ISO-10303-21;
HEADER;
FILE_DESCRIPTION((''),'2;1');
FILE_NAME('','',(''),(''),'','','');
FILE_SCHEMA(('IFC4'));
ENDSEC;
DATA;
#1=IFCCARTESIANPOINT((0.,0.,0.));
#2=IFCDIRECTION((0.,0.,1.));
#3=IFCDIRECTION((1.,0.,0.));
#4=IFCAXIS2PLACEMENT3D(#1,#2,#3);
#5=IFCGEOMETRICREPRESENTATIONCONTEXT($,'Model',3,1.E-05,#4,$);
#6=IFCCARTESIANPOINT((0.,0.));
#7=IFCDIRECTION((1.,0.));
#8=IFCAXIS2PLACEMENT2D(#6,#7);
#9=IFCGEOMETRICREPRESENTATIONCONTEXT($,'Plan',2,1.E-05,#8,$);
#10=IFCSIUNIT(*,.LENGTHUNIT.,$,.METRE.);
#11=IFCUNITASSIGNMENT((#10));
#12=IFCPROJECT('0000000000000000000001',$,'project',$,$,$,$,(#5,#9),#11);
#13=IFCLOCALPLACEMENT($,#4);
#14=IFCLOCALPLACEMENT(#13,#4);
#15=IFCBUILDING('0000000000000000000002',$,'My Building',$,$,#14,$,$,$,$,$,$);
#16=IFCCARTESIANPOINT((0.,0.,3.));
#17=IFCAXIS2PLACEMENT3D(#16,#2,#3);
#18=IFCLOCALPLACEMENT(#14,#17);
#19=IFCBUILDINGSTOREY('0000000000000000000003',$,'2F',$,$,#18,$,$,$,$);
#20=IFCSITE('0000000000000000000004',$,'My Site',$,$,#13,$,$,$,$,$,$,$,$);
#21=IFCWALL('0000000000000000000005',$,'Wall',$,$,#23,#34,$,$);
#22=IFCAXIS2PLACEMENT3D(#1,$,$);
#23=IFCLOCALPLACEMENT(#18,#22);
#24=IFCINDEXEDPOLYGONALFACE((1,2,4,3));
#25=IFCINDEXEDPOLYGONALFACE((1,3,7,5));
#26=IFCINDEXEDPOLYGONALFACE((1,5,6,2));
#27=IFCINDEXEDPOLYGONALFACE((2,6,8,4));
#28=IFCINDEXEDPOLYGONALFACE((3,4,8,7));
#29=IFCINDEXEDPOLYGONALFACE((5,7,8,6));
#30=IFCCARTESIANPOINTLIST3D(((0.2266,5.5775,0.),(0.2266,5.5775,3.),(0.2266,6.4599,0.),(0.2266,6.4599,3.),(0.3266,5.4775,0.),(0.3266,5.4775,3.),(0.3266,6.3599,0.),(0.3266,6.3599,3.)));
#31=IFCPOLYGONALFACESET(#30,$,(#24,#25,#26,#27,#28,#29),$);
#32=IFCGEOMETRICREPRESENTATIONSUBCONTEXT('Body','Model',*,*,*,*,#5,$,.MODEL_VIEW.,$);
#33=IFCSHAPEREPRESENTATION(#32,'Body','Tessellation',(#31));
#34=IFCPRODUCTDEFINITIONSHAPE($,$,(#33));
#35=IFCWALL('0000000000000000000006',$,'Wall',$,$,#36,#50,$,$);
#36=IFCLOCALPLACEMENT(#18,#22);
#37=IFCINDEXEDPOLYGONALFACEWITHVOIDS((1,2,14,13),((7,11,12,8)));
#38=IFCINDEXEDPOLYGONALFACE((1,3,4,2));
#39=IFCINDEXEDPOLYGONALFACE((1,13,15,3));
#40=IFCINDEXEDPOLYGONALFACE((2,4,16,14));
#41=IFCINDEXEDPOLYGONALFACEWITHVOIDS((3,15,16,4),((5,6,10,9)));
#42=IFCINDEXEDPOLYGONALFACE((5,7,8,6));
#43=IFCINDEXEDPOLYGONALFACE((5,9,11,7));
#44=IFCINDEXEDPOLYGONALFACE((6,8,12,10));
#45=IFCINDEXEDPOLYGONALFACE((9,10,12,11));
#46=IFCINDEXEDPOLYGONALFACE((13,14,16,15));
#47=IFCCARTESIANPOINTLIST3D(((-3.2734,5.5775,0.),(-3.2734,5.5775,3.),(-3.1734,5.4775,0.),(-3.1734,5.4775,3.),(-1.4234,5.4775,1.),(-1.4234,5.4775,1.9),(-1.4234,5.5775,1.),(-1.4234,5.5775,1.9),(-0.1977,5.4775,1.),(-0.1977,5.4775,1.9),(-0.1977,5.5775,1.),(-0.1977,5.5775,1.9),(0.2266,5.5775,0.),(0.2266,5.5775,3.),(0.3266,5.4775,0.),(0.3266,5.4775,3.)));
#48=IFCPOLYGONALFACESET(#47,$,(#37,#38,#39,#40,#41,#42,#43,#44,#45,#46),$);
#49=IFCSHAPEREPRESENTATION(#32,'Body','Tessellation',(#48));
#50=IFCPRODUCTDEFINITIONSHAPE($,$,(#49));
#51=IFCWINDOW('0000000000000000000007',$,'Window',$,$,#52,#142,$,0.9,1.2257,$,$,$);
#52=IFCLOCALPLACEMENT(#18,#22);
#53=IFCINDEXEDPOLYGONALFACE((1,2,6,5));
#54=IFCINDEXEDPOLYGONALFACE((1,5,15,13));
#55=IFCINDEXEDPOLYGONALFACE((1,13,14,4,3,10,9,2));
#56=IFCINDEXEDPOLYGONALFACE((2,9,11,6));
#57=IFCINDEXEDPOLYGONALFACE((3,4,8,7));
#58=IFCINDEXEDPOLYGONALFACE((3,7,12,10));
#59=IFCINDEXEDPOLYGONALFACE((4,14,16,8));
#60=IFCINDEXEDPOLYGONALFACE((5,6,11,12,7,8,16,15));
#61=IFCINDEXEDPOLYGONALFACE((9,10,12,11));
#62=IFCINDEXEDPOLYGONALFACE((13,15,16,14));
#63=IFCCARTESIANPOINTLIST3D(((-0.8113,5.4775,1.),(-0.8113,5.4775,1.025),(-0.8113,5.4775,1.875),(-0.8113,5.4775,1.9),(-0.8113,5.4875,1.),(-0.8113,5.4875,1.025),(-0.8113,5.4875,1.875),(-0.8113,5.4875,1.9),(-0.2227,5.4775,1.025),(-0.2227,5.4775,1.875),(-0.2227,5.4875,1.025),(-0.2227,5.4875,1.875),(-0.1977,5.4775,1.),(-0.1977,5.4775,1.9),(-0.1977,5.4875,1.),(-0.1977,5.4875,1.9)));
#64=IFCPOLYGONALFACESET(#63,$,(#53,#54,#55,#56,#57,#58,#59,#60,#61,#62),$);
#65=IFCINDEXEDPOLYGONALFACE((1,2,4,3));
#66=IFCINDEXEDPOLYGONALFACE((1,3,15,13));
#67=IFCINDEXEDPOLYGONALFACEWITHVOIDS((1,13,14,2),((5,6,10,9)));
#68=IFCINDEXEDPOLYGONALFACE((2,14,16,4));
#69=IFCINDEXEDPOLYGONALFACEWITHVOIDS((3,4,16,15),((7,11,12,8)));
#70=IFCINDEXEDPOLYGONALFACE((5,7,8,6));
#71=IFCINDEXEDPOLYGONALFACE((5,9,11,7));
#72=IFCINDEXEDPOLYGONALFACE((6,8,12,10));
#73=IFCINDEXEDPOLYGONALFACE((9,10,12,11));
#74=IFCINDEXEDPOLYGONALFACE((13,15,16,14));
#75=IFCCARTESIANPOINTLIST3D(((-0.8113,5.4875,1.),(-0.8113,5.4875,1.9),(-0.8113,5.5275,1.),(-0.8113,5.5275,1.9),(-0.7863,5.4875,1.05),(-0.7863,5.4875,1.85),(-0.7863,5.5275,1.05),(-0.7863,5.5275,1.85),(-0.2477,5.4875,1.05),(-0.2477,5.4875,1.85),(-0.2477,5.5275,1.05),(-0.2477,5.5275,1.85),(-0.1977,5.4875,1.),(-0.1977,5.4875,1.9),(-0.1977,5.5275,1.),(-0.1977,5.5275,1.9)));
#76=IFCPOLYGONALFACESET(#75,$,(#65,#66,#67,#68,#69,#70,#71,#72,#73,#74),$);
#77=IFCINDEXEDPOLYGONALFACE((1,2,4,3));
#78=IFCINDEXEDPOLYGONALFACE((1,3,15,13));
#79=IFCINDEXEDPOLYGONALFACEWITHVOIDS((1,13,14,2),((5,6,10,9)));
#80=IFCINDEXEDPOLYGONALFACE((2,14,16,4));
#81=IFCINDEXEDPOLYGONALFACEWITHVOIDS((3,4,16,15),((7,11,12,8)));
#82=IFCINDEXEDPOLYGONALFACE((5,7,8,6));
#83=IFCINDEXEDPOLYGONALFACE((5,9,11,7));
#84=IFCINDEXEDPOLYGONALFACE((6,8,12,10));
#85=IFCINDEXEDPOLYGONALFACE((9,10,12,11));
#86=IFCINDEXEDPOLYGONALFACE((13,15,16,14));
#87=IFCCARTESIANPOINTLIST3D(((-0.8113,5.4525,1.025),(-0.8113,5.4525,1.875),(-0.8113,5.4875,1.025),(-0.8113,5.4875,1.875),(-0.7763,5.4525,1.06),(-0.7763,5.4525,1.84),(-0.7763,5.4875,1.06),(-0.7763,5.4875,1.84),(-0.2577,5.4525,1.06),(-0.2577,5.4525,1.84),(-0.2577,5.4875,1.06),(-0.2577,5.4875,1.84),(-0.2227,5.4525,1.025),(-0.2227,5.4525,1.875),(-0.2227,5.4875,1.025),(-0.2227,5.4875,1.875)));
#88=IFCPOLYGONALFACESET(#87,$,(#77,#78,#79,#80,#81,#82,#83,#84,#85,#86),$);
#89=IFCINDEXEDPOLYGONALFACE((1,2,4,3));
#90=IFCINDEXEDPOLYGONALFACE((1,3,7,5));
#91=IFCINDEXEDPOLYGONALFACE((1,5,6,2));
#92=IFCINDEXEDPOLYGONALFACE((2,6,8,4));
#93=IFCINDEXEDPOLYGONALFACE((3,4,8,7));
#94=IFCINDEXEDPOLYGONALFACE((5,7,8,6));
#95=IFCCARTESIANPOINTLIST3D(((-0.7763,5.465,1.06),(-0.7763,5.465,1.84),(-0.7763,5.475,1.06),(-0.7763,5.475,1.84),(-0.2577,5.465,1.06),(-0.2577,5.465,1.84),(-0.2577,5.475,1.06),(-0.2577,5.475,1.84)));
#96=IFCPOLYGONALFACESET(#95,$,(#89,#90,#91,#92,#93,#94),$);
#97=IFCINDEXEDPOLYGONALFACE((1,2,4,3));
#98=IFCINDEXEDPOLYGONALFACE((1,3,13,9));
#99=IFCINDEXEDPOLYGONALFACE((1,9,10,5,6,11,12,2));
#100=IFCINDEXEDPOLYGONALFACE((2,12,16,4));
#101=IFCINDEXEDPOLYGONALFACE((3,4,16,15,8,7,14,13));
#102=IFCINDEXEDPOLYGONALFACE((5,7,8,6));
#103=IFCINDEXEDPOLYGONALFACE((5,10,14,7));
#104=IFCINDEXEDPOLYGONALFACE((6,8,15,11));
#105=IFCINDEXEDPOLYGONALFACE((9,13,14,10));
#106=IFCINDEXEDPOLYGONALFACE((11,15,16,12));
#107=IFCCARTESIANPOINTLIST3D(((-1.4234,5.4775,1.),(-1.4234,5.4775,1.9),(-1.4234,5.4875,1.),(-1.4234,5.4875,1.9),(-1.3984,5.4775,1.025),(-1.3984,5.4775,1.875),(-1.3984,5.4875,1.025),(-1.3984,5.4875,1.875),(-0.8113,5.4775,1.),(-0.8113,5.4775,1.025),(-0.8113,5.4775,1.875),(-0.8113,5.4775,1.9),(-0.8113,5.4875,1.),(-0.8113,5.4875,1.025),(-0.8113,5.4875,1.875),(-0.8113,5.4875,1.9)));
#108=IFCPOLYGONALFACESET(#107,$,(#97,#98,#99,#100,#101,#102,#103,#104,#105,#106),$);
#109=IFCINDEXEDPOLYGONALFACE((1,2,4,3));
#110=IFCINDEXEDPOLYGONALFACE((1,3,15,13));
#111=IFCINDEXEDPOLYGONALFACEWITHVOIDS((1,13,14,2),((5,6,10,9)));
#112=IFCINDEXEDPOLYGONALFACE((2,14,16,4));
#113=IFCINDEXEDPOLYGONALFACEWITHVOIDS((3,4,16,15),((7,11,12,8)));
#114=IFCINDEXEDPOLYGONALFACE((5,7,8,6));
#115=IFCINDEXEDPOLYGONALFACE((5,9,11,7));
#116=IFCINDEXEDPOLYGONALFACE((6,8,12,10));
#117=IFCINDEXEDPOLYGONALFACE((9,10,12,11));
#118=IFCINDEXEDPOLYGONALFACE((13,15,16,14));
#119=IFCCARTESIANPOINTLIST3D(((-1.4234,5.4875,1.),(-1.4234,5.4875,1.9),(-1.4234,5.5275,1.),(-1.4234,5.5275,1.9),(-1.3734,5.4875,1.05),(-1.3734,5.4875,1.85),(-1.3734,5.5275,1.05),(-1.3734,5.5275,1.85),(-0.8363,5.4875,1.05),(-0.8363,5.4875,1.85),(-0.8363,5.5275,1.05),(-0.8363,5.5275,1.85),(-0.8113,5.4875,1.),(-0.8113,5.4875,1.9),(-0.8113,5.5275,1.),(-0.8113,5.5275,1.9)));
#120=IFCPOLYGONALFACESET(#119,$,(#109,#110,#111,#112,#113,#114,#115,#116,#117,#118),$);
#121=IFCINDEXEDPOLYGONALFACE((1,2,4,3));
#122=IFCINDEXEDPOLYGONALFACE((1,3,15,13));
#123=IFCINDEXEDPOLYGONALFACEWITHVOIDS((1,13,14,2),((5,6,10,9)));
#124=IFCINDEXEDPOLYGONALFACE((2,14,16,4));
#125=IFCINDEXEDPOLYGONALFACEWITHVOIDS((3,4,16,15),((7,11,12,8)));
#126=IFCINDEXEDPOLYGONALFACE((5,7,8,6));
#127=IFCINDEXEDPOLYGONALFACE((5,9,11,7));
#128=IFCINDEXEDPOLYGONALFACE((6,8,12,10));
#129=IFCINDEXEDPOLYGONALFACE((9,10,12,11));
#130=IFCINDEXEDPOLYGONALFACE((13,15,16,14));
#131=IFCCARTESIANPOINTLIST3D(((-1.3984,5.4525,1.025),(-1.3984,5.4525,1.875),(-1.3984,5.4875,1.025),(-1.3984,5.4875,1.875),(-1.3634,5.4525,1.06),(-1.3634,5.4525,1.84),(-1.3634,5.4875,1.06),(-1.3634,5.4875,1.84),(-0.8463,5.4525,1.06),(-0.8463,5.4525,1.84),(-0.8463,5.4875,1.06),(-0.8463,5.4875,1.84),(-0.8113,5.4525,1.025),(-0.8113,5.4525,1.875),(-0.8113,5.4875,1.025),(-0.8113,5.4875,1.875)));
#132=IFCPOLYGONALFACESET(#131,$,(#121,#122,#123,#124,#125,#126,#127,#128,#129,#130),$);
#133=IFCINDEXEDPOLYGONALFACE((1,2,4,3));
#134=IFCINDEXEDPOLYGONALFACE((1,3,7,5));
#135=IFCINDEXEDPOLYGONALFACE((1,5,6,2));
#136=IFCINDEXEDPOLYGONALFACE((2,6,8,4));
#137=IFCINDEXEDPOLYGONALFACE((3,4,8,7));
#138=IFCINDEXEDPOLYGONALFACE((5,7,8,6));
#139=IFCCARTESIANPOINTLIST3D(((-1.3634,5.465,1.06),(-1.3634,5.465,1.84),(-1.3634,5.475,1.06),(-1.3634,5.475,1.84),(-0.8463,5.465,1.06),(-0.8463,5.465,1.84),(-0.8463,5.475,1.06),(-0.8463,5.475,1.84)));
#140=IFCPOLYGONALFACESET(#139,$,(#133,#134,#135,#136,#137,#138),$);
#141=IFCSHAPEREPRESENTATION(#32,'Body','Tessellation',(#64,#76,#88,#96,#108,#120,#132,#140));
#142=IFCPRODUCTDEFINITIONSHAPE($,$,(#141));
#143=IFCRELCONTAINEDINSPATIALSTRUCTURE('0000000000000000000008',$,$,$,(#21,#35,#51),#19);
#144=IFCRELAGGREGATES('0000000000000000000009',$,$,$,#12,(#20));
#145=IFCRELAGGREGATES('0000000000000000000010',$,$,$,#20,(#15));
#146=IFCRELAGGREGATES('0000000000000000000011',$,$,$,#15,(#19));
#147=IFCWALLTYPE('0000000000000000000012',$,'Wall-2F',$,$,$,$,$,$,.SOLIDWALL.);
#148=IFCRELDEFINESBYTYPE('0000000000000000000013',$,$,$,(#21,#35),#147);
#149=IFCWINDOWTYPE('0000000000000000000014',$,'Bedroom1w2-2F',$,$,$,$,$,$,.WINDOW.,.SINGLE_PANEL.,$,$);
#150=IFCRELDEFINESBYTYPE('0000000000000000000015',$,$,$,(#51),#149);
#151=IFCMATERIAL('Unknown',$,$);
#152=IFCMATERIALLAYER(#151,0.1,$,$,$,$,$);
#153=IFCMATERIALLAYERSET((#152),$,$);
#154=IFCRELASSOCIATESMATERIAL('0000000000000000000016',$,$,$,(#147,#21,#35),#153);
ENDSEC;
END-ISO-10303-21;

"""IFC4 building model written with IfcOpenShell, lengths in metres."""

from ifc_helpers import new_model, entity, si_unit, frame, origin_with_axes, origin_2d_with_axis, place, context, subcontext, project, spatial, line, indexed_curve, outline, extrude, shape, source, transform, mapped, material, layer, layer_set, layer_usage, type_object, type_shapes, element, fill, save


model = new_model("IFC4")

# Units and contexts
model_context = context("Model", 3, precision=1e-05, world=origin_with_axes())
plan_context = context("Plan", 2, precision=1e-05, world=origin_2d_with_axis())
body_context_1 = subcontext(model_context, "Body", "Model", "MODEL_VIEW")
body_context_2 = subcontext(plan_context, "Body", "Plan", "PLAN_VIEW")
ifc_project = project(units=[si_unit("LENGTHUNIT", "METRE")], contexts=[model_context, plan_context])

# Site, building, storey
site_placement = place(None, origin_with_axes())
site = spatial("IfcSite", under=ifc_project, at=site_placement, Name="My Site")
building_placement = place(site_placement, origin_with_axes())
building = spatial("IfcBuilding", under=site, at=building_placement, Name="My Building")
storey_placement = place(building_placement, frame((0.0, 0.0, 3.0), z_axis=(0.0, 0.0, 1.0), x_axis=(1.0, 0.0, 0.0)))
storey = spatial("IfcBuildingStorey", under=building, at=storey_placement, Name="2F")

# Shared definitions
ifc_material = material(Name="Unknown")

# Wall
ifc_layer_1 = layer(ifc_material, 0.1)
ifc_layer_set_1 = layer_set([ifc_layer_1])
wall_type_1 = type_object("IfcWallType", Name="Wall-2F", PredefinedType="SOLIDWALL", material=ifc_layer_set_1)
ifc_layer_usage_1 = layer_usage(ifc_layer_set_1, "AXIS2", "POSITIVE", 0.0)
wall_1_placement = place(storey_placement, frame((0.2266, 6.4599, 0.0), z_axis=(0.0, 0.0, 1.0), x_axis=(0.0, -1.0, 0.0)))
element("IfcWall", 1, at=wall_1_placement, inside=storey, type_object=wall_type_1, material=ifc_layer_usage_1, Name="Wall", context=body_context_1, shape_type="SweptSolid", body=[
    extrude(outline(indexed_curve([(0.0, 0.0), (0.1, 0.1), (0.9824, 0.1), (0.8824, 0.0)], segments=[line(1, 2, 3, 4, 1)])), origin_with_axes(), (0.0, 0.0, 1.0), 3.0),
])

# Wall, opening, window
ifc_layer_usage_2 = layer_usage(ifc_layer_set_1, "AXIS2", "POSITIVE", 0.0)
wall_2_placement = place(storey_placement, frame((0.2266, 5.5775, 0.0), z_axis=(0.0, 0.0, 1.0), x_axis=(-1.0, 0.0, 0.0)))
wall_2 = element("IfcWall", 2, at=wall_2_placement, inside=storey, type_object=wall_type_1, material=ifc_layer_usage_2, Name="Wall", context=body_context_1, shape_type="SweptSolid", body=[
    extrude(outline(indexed_curve([(0.0, 0.0), (-0.1, 0.1), (3.4, 0.1), (3.5, 0.0)], segments=[line(1, 2, 3, 4, 1)])), origin_with_axes(), (0.0, 0.0, 1.0), 3.0),
])
shared_shape_1 = source(origin_with_axes(), body_context_1, "Body", "SweptSolid", [
    extrude(outline(indexed_curve([(0.0, 0.0), (1.2257, 0.0), (1.2257, 0.9), (0.0, 0.9)], segments=[line(1, 2, 3, 4, 1)])), frame((0.0, -0.6, 0.0), z_axis=(0.0, -1.0, 0.0), x_axis=(1.0, 0.0, 0.0)), (0.0, 0.0, -1.0), 1.2),
])
opening_1_placement = place(wall_2_placement, frame((0.4243, 0.0, 1.0), z_axis=(0.0, 0.0, 1.0), x_axis=(1.0, 0.0, 0.0)))
opening_1 = element("IfcOpeningElement", 3, at=opening_1_placement, cuts=wall_2, PredefinedType="OPENING", context=body_context_1, shape_type="MappedRepresentation", body=[
    mapped(shared_shape_1, transform((0.0, 0.0, 0.0), x_axis=(1.0, 0.0, 0.0), y_axis=(0.0, 1.0, 0.0), z_axis=(0.0, 0.0, 1.0), scale=1.0)),
])
window_type_1 = type_object("IfcWindowType", Name="Bedroom1w2-2F", PartitioningType="SINGLE_PANEL", PredefinedType="WINDOW")
shared_shape_2 = source(origin_with_axes(), body_context_1, "Body", "SweptSolid", [
    extrude(outline(indexed_curve([(0.6136, 0.0), (0.0, 0.0), (0.0, 0.9), (0.6136, 0.9), (0.6136, 0.875), (0.025, 0.875), (0.025, 0.025), (0.6136, 0.025)], segments=[line(1, 2, 3, 4, 5, 6, 7, 8, 1)])), frame((0.0, 0.09, 0.0), z_axis=(0.0, -1.0, 0.0), x_axis=(1.0, 0.0, 0.0)), (0.0, 0.0, -1.0), 0.01),
    extrude(outline(indexed_curve([(0.0, 0.0), (0.6136, 0.0), (0.6136, 0.9), (0.0, 0.9)], segments=[line(1, 2, 3, 4, 1)]), holes=[indexed_curve([(0.05, 0.05), (0.5886, 0.05), (0.5886, 0.85), (0.05, 0.85)], segments=[line(1, 2, 3, 4, 1)])]), frame((0.0, 0.05, 0.0), z_axis=(0.0, -1.0, 0.0), x_axis=(1.0, 0.0, 0.0)), (0.0, 0.0, -1.0), 0.04),
    extrude(outline(indexed_curve([(0.0, 0.0), (0.5886, 0.0), (0.5886, 0.85), (0.0, 0.85)], segments=[line(1, 2, 3, 4, 1)]), holes=[indexed_curve([(0.035, 0.035), (0.5536, 0.035), (0.5536, 0.815), (0.035, 0.815)], segments=[line(1, 2, 3, 4, 1)])]), frame((0.025, 0.09, 0.025), z_axis=(0.0, -1.0, 0.0), x_axis=(1.0, 0.0, 0.0)), (0.0, 0.0, -1.0), 0.035),
    extrude(outline(indexed_curve([(0.035, 0.035), (0.5536, 0.035), (0.5536, 0.815), (0.035, 0.815)], segments=[line(1, 2, 3, 4, 1)])), frame((0.025, 0.1025, 0.025), z_axis=(0.0, -1.0, 0.0), x_axis=(1.0, 0.0, 0.0)), (0.0, 0.0, -1.0), 0.01),
    extrude(outline(indexed_curve([(0.0, 0.9), (0.6121, 0.9), (0.6121, 0.0), (0.0, 0.0), (0.0, 0.025), (0.5871, 0.025), (0.5871, 0.875), (0.0, 0.875)], segments=[line(1, 2, 3, 4, 5, 6, 7, 8, 1)])), frame((0.6136, 0.09, 0.0), z_axis=(0.0, -1.0, 0.0), x_axis=(1.0, 0.0, 0.0)), (0.0, 0.0, -1.0), 0.01),
    extrude(outline(indexed_curve([(0.0, 0.0), (0.6121, 0.0), (0.6121, 0.9), (0.0, 0.9)], segments=[line(1, 2, 3, 4, 1)]), holes=[indexed_curve([(0.025, 0.05), (0.5621, 0.05), (0.5621, 0.85), (0.025, 0.85)], segments=[line(1, 2, 3, 4, 1)])]), frame((0.6136, 0.05, 0.0), z_axis=(0.0, -1.0, 0.0), x_axis=(1.0, 0.0, 0.0)), (0.0, 0.0, -1.0), 0.04),
    extrude(outline(indexed_curve([(0.0, 0.0), (0.5871, 0.0), (0.5871, 0.85), (0.0, 0.85)], segments=[line(1, 2, 3, 4, 1)]), holes=[indexed_curve([(0.035, 0.035), (0.5521, 0.035), (0.5521, 0.815), (0.035, 0.815)], segments=[line(1, 2, 3, 4, 1)])]), frame((0.6136, 0.09, 0.025), z_axis=(0.0, -1.0, 0.0), x_axis=(1.0, 0.0, 0.0)), (0.0, 0.0, -1.0), 0.035),
    extrude(outline(indexed_curve([(0.035, 0.035), (0.5521, 0.035), (0.5521, 0.815), (0.035, 0.815)], segments=[line(1, 2, 3, 4, 1)])), frame((0.6136, 0.1025, 0.025), z_axis=(0.0, -1.0, 0.0), x_axis=(1.0, 0.0, 0.0)), (0.0, 0.0, -1.0), 0.01),
])
shared_shape_3 = source(origin_with_axes(), body_context_2, "Body", "Curve2D", [
    entity("IfcIndexedPolyCurve", entity("IfcCartesianPointList2D", [[0.05, 0.05], [0.5886, 0.05]])),
    entity("IfcIndexedPolyCurve", entity("IfcCartesianPointList2D", [[0.0, 0.1], [0.025, 0.1], [0.025, 0.09], [0.05, 0.09], [0.05, 0.05], [0.0, 0.05]]), [entity("IfcLineIndex", [1, 2, 3, 4, 5, 6, 1])]),
    entity("IfcIndexedPolyCurve", entity("IfcCartesianPointList2D", [[0.6136, 0.1], [0.6136, 0.1], [0.6136, 0.09], [0.5886, 0.09], [0.5886, 0.05], [0.6136, 0.05]])),
    entity("IfcIndexedPolyCurve", entity("IfcCartesianPointList2D", [[0.025, 0.09], [0.06, 0.09], [0.06, 0.125], [0.025, 0.125]]), [entity("IfcLineIndex", [1, 2, 3, 4, 1])]),
    entity("IfcIndexedPolyCurve", entity("IfcCartesianPointList2D", [[0.6136, 0.09], [0.5786, 0.09], [0.5786, 0.125], [0.6136, 0.125]]), [entity("IfcLineIndex", [1, 2, 3, 4, 1])]),
    entity("IfcIndexedPolyCurve", entity("IfcCartesianPointList2D", [[0.06, 0.09], [0.5786, 0.09]])),
    entity("IfcIndexedPolyCurve", entity("IfcCartesianPointList2D", [[0.06, 0.125], [0.5786, 0.125]])),
    entity("IfcIndexedPolyCurve", entity("IfcCartesianPointList2D", [[0.06, 0.1075], [0.5786, 0.1075]])),
    entity("IfcIndexedPolyCurve", entity("IfcCartesianPointList2D", [[0.6386, 0.05], [1.1757, 0.05]])),
    entity("IfcIndexedPolyCurve", entity("IfcCartesianPointList2D", [[0.6136, 0.1], [0.6136, 0.1], [0.6136, 0.09], [0.6386, 0.09], [0.6386, 0.05], [0.6136, 0.05]])),
    entity("IfcIndexedPolyCurve", entity("IfcCartesianPointList2D", [[1.2257, 0.1], [1.2007, 0.1], [1.2007, 0.09], [1.1757, 0.09], [1.1757, 0.05], [1.2257, 0.05]]), [entity("IfcLineIndex", [1, 2, 3, 4, 5, 6, 1])]),
    entity("IfcIndexedPolyCurve", entity("IfcCartesianPointList2D", [[0.6136, 0.09], [0.6486, 0.09], [0.6486, 0.125], [0.6136, 0.125]]), [entity("IfcLineIndex", [1, 2, 3, 4, 1])]),
    entity("IfcIndexedPolyCurve", entity("IfcCartesianPointList2D", [[1.2007, 0.09], [1.1657, 0.09], [1.1657, 0.125], [1.2007, 0.125]]), [entity("IfcLineIndex", [1, 2, 3, 4, 1])]),
    entity("IfcIndexedPolyCurve", entity("IfcCartesianPointList2D", [[0.6486, 0.09], [1.1657, 0.09]])),
    entity("IfcIndexedPolyCurve", entity("IfcCartesianPointList2D", [[0.6486, 0.125], [1.1657, 0.125]])),
    entity("IfcIndexedPolyCurve", entity("IfcCartesianPointList2D", [[0.6486, 0.1075], [1.1657, 0.1075]])),
])
type_shapes(window_type_1, [shared_shape_2, shared_shape_3])
window_1_placement = place(opening_1_placement, frame((0.0, 0.0, 0.0), z_axis=(0.0, 0.0, 1.0), x_axis=(1.0, 0.0, 0.0)))
window_1 = element("IfcWindow", 4, at=window_1_placement, inside=storey, type_object=window_type_1, Name="Window", OverallHeight=0.9, OverallWidth=1.2257, shapes=[
    shape(body_context_1, "Body", "MappedRepresentation", [mapped(shared_shape_2, transform((0.0, 0.0, 0.0), x_axis=(1.0, 0.0, 0.0), y_axis=(0.0, 1.0, 0.0), z_axis=(0.0, 0.0, 1.0), scale=1.0))]),
    shape(body_context_2, "Body", "MappedRepresentation", [mapped(shared_shape_3, transform((0.0, 0.0, 0.0), x_axis=(1.0, 0.0, 0.0), y_axis=(0.0, 1.0, 0.0), z_axis=(0.0, 0.0, 1.0), scale=1.0))]),
])
fill(opening_1, window_1)

save(model, "model.ifc")
